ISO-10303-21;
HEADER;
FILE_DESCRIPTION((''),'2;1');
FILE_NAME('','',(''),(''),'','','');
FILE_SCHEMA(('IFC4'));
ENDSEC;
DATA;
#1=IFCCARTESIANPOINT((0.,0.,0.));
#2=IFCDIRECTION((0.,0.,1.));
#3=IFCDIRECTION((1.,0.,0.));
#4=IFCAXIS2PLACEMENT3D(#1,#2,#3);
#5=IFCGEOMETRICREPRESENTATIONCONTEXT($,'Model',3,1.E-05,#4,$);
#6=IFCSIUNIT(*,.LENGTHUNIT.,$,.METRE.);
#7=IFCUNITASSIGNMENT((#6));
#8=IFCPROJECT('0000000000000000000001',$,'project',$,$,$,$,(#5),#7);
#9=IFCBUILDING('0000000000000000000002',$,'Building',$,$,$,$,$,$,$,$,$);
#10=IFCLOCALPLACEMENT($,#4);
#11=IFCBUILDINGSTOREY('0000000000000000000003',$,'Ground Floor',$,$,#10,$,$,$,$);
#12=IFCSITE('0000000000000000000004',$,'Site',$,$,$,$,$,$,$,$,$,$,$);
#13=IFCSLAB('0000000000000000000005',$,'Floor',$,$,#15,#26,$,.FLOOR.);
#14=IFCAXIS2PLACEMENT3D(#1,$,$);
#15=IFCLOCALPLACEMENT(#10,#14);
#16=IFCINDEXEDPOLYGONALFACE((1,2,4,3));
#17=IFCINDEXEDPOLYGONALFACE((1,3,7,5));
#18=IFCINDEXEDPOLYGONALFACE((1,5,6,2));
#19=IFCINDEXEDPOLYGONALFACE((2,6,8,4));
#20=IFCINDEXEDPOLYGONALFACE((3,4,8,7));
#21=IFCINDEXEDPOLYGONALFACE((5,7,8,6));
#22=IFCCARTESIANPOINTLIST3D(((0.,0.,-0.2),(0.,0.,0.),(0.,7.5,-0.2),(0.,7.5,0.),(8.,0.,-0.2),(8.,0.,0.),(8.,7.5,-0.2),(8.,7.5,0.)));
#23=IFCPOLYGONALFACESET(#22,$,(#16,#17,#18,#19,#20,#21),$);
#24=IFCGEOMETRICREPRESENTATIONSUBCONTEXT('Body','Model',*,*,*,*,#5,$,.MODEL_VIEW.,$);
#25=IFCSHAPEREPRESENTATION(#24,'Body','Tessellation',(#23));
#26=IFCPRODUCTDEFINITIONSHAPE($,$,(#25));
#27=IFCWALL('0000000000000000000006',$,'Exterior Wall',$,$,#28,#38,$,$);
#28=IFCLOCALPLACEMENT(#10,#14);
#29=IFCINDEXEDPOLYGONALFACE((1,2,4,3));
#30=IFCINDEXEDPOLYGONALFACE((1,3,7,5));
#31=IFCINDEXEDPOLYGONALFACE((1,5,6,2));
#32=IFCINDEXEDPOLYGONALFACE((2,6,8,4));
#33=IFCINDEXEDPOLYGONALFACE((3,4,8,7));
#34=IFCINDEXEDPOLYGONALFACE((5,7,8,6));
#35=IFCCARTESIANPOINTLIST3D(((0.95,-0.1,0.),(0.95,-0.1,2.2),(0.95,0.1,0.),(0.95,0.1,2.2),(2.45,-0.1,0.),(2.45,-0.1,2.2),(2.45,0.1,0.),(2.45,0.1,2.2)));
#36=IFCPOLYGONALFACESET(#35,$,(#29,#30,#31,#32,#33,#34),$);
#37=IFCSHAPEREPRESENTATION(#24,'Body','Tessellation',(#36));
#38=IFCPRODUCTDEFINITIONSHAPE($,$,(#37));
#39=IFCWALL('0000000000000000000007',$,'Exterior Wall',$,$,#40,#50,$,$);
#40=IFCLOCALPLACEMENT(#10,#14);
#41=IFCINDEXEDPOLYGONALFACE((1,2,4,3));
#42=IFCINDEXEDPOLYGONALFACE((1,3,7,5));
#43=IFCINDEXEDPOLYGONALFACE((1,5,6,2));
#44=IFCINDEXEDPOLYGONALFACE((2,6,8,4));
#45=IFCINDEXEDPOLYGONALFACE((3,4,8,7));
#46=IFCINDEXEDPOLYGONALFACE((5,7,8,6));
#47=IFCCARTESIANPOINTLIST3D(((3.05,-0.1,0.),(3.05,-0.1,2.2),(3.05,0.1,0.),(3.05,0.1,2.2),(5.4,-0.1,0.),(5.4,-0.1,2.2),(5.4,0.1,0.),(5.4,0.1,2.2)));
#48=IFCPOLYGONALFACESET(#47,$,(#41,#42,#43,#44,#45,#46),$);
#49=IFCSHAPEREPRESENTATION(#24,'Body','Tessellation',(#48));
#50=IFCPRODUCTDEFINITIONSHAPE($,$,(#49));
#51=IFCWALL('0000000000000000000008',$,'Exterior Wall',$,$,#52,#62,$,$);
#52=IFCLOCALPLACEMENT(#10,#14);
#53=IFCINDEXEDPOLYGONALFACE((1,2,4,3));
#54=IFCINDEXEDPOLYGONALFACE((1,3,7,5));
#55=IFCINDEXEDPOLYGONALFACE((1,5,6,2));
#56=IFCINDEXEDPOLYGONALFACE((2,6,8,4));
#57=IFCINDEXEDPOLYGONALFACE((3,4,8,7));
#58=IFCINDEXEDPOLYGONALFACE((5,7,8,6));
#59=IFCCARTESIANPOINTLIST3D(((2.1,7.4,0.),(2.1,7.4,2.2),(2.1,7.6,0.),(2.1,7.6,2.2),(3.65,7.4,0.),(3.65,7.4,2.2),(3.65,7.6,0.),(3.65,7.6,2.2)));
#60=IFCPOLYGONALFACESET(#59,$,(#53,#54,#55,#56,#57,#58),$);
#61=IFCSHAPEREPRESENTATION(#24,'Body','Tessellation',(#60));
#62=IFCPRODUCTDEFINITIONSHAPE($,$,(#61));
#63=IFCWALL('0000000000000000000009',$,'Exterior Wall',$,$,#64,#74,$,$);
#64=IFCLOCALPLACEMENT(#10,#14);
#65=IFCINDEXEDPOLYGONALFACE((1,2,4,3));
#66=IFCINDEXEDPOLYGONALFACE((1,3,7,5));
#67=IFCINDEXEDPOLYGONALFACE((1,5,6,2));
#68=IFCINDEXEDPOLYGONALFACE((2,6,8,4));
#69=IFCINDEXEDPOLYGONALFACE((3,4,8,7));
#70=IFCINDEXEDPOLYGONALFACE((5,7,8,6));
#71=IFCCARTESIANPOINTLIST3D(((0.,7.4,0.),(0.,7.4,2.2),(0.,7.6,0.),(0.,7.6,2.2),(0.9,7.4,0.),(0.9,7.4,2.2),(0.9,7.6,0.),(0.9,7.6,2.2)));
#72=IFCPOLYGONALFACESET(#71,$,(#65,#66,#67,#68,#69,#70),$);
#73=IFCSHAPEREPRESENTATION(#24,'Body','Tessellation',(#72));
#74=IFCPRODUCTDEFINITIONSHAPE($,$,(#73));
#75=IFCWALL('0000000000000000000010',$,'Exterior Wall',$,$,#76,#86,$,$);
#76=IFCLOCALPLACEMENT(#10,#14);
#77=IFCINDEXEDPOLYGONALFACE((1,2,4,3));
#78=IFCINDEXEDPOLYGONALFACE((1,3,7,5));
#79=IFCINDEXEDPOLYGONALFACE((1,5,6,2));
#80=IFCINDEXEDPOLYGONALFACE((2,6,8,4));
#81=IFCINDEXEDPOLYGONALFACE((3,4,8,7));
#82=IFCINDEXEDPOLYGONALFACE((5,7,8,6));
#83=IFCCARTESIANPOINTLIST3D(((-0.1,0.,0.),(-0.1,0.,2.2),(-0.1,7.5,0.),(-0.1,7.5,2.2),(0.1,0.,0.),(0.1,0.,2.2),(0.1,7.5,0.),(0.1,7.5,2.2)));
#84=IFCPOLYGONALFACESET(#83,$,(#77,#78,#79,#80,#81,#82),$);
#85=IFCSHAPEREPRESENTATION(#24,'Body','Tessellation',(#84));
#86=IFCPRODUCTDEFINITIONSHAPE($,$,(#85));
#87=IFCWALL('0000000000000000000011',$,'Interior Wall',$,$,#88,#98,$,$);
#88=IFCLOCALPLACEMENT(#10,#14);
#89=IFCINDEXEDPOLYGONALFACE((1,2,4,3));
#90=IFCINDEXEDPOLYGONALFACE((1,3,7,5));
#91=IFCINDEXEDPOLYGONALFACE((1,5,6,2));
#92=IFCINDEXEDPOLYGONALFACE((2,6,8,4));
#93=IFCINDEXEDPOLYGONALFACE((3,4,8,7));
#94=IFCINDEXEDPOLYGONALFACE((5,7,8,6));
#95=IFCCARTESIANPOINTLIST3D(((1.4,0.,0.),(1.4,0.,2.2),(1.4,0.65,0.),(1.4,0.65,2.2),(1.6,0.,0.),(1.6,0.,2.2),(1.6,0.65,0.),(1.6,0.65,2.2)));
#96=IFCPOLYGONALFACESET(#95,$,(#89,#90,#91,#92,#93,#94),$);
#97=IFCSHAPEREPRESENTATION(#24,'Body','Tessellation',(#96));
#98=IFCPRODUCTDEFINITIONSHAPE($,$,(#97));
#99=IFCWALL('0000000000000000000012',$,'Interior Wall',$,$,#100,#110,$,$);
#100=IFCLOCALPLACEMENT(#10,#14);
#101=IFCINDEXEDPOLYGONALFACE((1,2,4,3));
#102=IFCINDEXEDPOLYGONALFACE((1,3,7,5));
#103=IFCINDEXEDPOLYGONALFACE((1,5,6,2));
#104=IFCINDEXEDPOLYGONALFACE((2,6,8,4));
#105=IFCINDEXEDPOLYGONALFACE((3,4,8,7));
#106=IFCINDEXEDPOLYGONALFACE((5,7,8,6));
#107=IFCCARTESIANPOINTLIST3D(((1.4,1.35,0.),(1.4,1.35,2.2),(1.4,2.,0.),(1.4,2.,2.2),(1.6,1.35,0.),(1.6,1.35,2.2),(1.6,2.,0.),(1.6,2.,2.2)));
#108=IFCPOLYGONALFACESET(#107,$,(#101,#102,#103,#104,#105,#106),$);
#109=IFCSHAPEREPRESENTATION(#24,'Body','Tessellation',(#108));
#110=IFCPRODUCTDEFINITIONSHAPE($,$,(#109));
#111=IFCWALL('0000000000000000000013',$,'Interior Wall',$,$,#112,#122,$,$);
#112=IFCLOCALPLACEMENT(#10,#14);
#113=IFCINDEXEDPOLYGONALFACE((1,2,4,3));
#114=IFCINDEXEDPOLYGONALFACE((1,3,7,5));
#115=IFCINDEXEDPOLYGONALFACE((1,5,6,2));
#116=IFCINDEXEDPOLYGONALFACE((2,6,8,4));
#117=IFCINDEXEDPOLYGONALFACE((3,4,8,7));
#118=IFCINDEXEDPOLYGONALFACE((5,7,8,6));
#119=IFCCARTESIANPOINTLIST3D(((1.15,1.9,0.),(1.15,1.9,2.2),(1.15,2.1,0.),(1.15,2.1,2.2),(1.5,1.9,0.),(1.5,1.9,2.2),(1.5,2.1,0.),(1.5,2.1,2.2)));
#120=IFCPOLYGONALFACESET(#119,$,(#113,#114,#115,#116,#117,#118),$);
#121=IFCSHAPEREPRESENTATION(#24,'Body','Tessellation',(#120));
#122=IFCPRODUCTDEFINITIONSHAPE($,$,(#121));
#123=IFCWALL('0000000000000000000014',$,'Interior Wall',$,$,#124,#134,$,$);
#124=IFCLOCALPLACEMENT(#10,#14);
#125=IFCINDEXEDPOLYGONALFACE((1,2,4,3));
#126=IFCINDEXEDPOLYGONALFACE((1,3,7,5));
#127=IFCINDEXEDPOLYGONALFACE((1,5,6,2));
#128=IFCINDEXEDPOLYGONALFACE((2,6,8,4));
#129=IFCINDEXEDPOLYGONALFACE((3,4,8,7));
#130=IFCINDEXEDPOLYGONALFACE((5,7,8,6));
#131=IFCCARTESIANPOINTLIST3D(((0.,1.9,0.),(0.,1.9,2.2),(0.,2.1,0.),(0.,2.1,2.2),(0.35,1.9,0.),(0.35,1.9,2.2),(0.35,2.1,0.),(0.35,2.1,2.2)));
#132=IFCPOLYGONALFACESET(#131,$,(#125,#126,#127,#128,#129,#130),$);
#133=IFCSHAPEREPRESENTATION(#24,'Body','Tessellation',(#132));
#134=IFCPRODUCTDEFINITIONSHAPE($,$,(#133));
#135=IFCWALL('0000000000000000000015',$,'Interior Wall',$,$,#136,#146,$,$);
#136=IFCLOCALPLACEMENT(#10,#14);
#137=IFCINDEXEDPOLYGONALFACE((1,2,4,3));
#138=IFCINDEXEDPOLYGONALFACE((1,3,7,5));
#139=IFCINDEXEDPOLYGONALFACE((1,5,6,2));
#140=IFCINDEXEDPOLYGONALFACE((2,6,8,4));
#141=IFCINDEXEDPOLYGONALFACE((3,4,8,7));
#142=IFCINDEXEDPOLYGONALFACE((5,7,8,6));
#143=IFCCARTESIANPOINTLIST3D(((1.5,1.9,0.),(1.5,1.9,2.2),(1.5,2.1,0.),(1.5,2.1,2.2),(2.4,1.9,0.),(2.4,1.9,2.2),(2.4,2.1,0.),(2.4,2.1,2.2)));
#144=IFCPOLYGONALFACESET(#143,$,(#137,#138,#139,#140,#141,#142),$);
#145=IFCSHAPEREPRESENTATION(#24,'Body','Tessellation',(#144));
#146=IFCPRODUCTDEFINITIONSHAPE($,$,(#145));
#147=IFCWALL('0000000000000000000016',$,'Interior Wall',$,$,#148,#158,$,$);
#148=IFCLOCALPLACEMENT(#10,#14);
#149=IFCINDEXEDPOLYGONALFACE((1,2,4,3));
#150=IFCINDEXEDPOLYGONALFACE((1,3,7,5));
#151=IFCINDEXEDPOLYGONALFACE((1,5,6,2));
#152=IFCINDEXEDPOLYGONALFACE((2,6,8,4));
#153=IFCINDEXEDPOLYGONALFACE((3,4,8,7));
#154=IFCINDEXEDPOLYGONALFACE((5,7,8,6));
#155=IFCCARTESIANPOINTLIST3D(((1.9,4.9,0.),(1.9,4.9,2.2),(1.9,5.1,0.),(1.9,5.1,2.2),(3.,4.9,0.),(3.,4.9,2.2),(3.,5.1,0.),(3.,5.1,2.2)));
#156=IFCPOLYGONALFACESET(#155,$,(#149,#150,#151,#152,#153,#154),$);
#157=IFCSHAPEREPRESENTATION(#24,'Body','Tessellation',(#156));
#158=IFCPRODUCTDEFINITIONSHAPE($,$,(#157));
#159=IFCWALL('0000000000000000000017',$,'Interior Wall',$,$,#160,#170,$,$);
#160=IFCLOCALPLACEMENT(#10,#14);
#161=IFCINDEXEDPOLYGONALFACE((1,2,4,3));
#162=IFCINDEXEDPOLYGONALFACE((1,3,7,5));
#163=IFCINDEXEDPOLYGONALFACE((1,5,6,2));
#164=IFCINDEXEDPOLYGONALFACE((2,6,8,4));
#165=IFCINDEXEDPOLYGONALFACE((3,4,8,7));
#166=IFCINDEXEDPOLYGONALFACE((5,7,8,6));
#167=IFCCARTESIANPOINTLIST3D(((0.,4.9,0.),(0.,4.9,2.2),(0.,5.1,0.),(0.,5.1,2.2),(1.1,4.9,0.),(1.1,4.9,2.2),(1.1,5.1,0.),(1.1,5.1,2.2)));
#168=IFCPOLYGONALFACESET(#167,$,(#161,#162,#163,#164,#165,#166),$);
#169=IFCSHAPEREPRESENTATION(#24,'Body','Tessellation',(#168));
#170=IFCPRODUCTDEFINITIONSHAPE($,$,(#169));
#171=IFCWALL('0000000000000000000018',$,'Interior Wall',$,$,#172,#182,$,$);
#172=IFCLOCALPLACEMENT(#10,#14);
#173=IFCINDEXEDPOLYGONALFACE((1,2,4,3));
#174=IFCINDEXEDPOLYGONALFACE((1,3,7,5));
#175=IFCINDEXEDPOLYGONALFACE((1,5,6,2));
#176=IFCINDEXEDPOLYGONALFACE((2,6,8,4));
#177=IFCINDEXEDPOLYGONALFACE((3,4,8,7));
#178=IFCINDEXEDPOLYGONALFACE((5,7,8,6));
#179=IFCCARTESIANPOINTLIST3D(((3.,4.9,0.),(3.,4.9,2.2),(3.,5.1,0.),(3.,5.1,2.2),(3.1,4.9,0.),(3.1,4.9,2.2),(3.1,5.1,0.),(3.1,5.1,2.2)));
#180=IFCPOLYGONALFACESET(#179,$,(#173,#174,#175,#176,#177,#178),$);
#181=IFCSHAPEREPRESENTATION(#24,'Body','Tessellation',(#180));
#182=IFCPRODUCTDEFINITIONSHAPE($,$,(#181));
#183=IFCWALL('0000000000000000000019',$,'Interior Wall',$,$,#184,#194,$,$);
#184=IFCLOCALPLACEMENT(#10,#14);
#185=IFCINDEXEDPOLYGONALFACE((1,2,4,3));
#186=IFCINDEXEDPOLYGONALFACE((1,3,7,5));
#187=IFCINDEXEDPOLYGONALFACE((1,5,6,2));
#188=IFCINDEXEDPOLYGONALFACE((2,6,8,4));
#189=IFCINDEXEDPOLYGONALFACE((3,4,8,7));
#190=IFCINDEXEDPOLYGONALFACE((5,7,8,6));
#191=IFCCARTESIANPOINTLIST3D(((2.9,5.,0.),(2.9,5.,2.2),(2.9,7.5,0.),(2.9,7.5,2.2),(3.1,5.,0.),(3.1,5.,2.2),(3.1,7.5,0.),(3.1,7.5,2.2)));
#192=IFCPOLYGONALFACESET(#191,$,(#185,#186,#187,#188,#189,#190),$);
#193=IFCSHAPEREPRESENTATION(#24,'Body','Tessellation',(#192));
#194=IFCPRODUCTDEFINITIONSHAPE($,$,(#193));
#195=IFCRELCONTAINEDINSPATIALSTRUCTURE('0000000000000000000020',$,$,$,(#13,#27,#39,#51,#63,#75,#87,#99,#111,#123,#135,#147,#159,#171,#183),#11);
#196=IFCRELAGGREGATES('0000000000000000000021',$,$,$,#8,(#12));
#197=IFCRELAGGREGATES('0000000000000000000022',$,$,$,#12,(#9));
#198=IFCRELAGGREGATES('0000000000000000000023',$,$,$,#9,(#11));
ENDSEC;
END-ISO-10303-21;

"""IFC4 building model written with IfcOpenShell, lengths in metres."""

from ifc_helpers import new_model, si_unit, frame, origin_with_axes, place, context, subcontext, project, spatial, indexed_curve, outline, extrude, element, save


model = new_model("IFC4")

# Units and contexts
model_context = context("Model", 3, precision=1e-05, world=origin_with_axes())
body_context = subcontext(model_context, "Body", "Model", "MODEL_VIEW")
ifc_project = project(units=[si_unit("LENGTHUNIT", "METRE")], contexts=[model_context])

# Site, building, storey
site = spatial("IfcSite", under=ifc_project, Name="Site")
building = spatial("IfcBuilding", under=site, Name="Building")
storey_placement = place(None, origin_with_axes())
storey = spatial("IfcBuildingStorey", under=building, at=storey_placement, Name="Ground Floor")

# Slab
slab_placement = place(storey_placement, frame((0.0, 0.0, -0.2), z_axis=(0.0, 0.0, 1.0), x_axis=(1.0, 0.0, 0.0)))
element("IfcSlab", 1, at=slab_placement, inside=storey, Name="Floor", PredefinedType="FLOOR", context=body_context, shape_type="SweptSolid", body=[
    extrude(outline(indexed_curve([(0.0, 0.0), (8.0, 0.0), (8.0, 7.5), (0.0, 7.5)])), None, (0.0, 0.0, 1.0), 0.2),
])

# Walls
wall_1_placement = place(storey_placement, frame((0.95, 0.0, 0.0), z_axis=(0.0, 0.0, 1.0), x_axis=(1.0, 0.0, 0.0)))
element("IfcWall", 2, at=wall_1_placement, inside=storey, Name="Exterior Wall", context=body_context, shape_type="SweptSolid", body=[
    extrude(outline(indexed_curve([(0.0, 0.0), (0.0, 0.2), (1.5, 0.2), (1.5, 0.0), (0.0, 0.0)], self_intersect=False)), frame((0.0, -0.1, 0.0), z_axis=(0.0, 0.0, 1.0), x_axis=(1.0, 0.0, 0.0)), (0.0, 0.0, 1.0), 2.2),
])
wall_2_placement = place(storey_placement, frame((3.05, 0.0, 0.0), z_axis=(0.0, 0.0, 1.0), x_axis=(1.0, 0.0, 0.0)))
element("IfcWall", 3, at=wall_2_placement, inside=storey, Name="Exterior Wall", context=body_context, shape_type="SweptSolid", body=[
    extrude(outline(indexed_curve([(0.0, 0.0), (0.0, 0.2), (2.35, 0.2), (2.35, 0.0), (0.0, 0.0)], self_intersect=False)), frame((0.0, -0.1, 0.0), z_axis=(0.0, 0.0, 1.0), x_axis=(1.0, 0.0, 0.0)), (0.0, 0.0, 1.0), 2.2),
])
wall_3_placement = place(storey_placement, frame((3.65, 7.5, 0.0), z_axis=(0.0, 0.0, 1.0), x_axis=(-1.0, 0.0, 0.0)))
element("IfcWall", 4, at=wall_3_placement, inside=storey, Name="Exterior Wall", context=body_context, shape_type="SweptSolid", body=[
    extrude(outline(indexed_curve([(0.0, 0.0), (0.0, 0.2), (1.55, 0.2), (1.55, 0.0), (0.0, 0.0)], self_intersect=False)), frame((0.0, -0.1, 0.0), z_axis=(0.0, 0.0, 1.0), x_axis=(1.0, 0.0, 0.0)), (0.0, 0.0, 1.0), 2.2),
])
wall_4_placement = place(storey_placement, frame((0.9, 7.5, 0.0), z_axis=(0.0, 0.0, 1.0), x_axis=(-1.0, 0.0, 0.0)))
element("IfcWall", 5, at=wall_4_placement, inside=storey, Name="Exterior Wall", context=body_context, shape_type="SweptSolid", body=[
    extrude(outline(indexed_curve([(0.0, 0.0), (0.0, 0.2), (0.9, 0.2), (0.9, 0.0), (0.0, 0.0)], self_intersect=False)), frame((0.0, -0.1, 0.0), z_axis=(0.0, 0.0, 1.0), x_axis=(1.0, 0.0, 0.0)), (0.0, 0.0, 1.0), 2.2),
])
wall_5_placement = place(storey_placement, frame((0.0, 7.5, 0.0), z_axis=(0.0, 0.0, 1.0), x_axis=(0.0, -1.0, 0.0)))
element("IfcWall", 6, at=wall_5_placement, inside=storey, Name="Exterior Wall", context=body_context, shape_type="SweptSolid", body=[
    extrude(outline(indexed_curve([(0.0, 0.0), (0.0, 0.2), (7.5, 0.2), (7.5, 0.0), (0.0, 0.0)], self_intersect=False)), frame((0.0, -0.1, 0.0), z_axis=(0.0, 0.0, 1.0), x_axis=(1.0, 0.0, 0.0)), (0.0, 0.0, 1.0), 2.2),
])
wall_6_placement = place(storey_placement, frame((1.5, 0.0, 0.0), z_axis=(0.0, 0.0, 1.0), x_axis=(0.0, 1.0, 0.0)))
element("IfcWall", 7, at=wall_6_placement, inside=storey, Name="Interior Wall", context=body_context, shape_type="SweptSolid", body=[
    extrude(outline(indexed_curve([(0.0, 0.0), (0.0, 0.2), (0.65, 0.2), (0.65, 0.0), (0.0, 0.0)], self_intersect=False)), frame((0.0, -0.1, 0.0), z_axis=(0.0, 0.0, 1.0), x_axis=(1.0, 0.0, 0.0)), (0.0, 0.0, 1.0), 2.2),
])
wall_7_placement = place(storey_placement, frame((1.5, 1.35, 0.0), z_axis=(0.0, 0.0, 1.0), x_axis=(0.0, 1.0, 0.0)))
element("IfcWall", 8, at=wall_7_placement, inside=storey, Name="Interior Wall", context=body_context, shape_type="SweptSolid", body=[
    extrude(outline(indexed_curve([(0.0, 0.0), (0.0, 0.2), (0.65, 0.2), (0.65, 0.0), (0.0, 0.0)], self_intersect=False)), frame((0.0, -0.1, 0.0), z_axis=(0.0, 0.0, 1.0), x_axis=(1.0, 0.0, 0.0)), (0.0, 0.0, 1.0), 2.2),
])
for number, where, z_axis, x_axis, name in (
    (9, (1.5, 2.0, 0.0), (0.0, 0.0, 1.0), (-1.0, 0.0, 0.0), "Interior Wall"),
    (10, (0.35, 2.0, 0.0), (0.0, 0.0, 1.0), (-1.0, 0.0, 0.0), "Interior Wall"),
):
    element("IfcWall", number, at=place(storey_placement, frame(where, z_axis=z_axis, x_axis=x_axis)), inside=storey, Name=name, context=body_context, shape_type="SweptSolid", body=[
        extrude(outline(indexed_curve([(0.0, 0.0), (0.0, 0.2), (0.35, 0.2), (0.35, 0.0), (0.0, 0.0)], self_intersect=False)), frame((0.0, -0.1, 0.0), z_axis=(0.0, 0.0, 1.0), x_axis=(1.0, 0.0, 0.0)), (0.0, 0.0, 1.0), 2.2),
    ])
wall_8_placement = place(storey_placement, frame((2.4, 2.0, 0.0), z_axis=(0.0, 0.0, 1.0), x_axis=(-1.0, 0.0, 0.0)))
element("IfcWall", 11, at=wall_8_placement, inside=storey, Name="Interior Wall", context=body_context, shape_type="SweptSolid", body=[
    extrude(outline(indexed_curve([(0.0, 0.0), (0.0, 0.2), (0.9, 0.2), (0.9, 0.0), (0.0, 0.0)], self_intersect=False)), frame((0.0, -0.1, 0.0), z_axis=(0.0, 0.0, 1.0), x_axis=(1.0, 0.0, 0.0)), (0.0, 0.0, 1.0), 2.2),
])
for number, where, z_axis, x_axis, name in (
    (12, (3.0, 5.0, 0.0), (0.0, 0.0, 1.0), (-1.0, 0.0, 0.0), "Interior Wall"),
    (13, (1.1, 5.0, 0.0), (0.0, 0.0, 1.0), (-1.0, 0.0, 0.0), "Interior Wall"),
):
    element("IfcWall", number, at=place(storey_placement, frame(where, z_axis=z_axis, x_axis=x_axis)), inside=storey, Name=name, context=body_context, shape_type="SweptSolid", body=[
        extrude(outline(indexed_curve([(0.0, 0.0), (0.0, 0.2), (1.1, 0.2), (1.1, 0.0), (0.0, 0.0)], self_intersect=False)), frame((0.0, -0.1, 0.0), z_axis=(0.0, 0.0, 1.0), x_axis=(1.0, 0.0, 0.0)), (0.0, 0.0, 1.0), 2.2),
    ])
wall_9_placement = place(storey_placement, frame((3.1, 5.0, 0.0), z_axis=(0.0, 0.0, 1.0), x_axis=(-1.0, 0.0, 0.0)))
element("IfcWall", 14, at=wall_9_placement, inside=storey, Name="Interior Wall", context=body_context, shape_type="SweptSolid", body=[
    extrude(outline(indexed_curve([(0.0, 0.0), (0.0, 0.2), (0.1, 0.2), (0.1, 0.0), (0.0, 0.0)], self_intersect=False)), frame((0.0, -0.1, 0.0), z_axis=(0.0, 0.0, 1.0), x_axis=(1.0, 0.0, 0.0)), (0.0, 0.0, 1.0), 2.2),
])
wall_10_placement = place(storey_placement, frame((3.0, 5.0, 0.0), z_axis=(0.0, 0.0, 1.0), x_axis=(0.0, 1.0, 0.0)))
element("IfcWall", 15, at=wall_10_placement, inside=storey, Name="Interior Wall", context=body_context, shape_type="SweptSolid", body=[
    extrude(outline(indexed_curve([(0.0, 0.0), (0.0, 0.2), (2.5, 0.2), (2.5, 0.0), (0.0, 0.0)], self_intersect=False)), frame((0.0, -0.1, 0.0), z_axis=(0.0, 0.0, 1.0), x_axis=(1.0, 0.0, 0.0)), (0.0, 0.0, 1.0), 2.2),
])

save(model, "model.ifc")
